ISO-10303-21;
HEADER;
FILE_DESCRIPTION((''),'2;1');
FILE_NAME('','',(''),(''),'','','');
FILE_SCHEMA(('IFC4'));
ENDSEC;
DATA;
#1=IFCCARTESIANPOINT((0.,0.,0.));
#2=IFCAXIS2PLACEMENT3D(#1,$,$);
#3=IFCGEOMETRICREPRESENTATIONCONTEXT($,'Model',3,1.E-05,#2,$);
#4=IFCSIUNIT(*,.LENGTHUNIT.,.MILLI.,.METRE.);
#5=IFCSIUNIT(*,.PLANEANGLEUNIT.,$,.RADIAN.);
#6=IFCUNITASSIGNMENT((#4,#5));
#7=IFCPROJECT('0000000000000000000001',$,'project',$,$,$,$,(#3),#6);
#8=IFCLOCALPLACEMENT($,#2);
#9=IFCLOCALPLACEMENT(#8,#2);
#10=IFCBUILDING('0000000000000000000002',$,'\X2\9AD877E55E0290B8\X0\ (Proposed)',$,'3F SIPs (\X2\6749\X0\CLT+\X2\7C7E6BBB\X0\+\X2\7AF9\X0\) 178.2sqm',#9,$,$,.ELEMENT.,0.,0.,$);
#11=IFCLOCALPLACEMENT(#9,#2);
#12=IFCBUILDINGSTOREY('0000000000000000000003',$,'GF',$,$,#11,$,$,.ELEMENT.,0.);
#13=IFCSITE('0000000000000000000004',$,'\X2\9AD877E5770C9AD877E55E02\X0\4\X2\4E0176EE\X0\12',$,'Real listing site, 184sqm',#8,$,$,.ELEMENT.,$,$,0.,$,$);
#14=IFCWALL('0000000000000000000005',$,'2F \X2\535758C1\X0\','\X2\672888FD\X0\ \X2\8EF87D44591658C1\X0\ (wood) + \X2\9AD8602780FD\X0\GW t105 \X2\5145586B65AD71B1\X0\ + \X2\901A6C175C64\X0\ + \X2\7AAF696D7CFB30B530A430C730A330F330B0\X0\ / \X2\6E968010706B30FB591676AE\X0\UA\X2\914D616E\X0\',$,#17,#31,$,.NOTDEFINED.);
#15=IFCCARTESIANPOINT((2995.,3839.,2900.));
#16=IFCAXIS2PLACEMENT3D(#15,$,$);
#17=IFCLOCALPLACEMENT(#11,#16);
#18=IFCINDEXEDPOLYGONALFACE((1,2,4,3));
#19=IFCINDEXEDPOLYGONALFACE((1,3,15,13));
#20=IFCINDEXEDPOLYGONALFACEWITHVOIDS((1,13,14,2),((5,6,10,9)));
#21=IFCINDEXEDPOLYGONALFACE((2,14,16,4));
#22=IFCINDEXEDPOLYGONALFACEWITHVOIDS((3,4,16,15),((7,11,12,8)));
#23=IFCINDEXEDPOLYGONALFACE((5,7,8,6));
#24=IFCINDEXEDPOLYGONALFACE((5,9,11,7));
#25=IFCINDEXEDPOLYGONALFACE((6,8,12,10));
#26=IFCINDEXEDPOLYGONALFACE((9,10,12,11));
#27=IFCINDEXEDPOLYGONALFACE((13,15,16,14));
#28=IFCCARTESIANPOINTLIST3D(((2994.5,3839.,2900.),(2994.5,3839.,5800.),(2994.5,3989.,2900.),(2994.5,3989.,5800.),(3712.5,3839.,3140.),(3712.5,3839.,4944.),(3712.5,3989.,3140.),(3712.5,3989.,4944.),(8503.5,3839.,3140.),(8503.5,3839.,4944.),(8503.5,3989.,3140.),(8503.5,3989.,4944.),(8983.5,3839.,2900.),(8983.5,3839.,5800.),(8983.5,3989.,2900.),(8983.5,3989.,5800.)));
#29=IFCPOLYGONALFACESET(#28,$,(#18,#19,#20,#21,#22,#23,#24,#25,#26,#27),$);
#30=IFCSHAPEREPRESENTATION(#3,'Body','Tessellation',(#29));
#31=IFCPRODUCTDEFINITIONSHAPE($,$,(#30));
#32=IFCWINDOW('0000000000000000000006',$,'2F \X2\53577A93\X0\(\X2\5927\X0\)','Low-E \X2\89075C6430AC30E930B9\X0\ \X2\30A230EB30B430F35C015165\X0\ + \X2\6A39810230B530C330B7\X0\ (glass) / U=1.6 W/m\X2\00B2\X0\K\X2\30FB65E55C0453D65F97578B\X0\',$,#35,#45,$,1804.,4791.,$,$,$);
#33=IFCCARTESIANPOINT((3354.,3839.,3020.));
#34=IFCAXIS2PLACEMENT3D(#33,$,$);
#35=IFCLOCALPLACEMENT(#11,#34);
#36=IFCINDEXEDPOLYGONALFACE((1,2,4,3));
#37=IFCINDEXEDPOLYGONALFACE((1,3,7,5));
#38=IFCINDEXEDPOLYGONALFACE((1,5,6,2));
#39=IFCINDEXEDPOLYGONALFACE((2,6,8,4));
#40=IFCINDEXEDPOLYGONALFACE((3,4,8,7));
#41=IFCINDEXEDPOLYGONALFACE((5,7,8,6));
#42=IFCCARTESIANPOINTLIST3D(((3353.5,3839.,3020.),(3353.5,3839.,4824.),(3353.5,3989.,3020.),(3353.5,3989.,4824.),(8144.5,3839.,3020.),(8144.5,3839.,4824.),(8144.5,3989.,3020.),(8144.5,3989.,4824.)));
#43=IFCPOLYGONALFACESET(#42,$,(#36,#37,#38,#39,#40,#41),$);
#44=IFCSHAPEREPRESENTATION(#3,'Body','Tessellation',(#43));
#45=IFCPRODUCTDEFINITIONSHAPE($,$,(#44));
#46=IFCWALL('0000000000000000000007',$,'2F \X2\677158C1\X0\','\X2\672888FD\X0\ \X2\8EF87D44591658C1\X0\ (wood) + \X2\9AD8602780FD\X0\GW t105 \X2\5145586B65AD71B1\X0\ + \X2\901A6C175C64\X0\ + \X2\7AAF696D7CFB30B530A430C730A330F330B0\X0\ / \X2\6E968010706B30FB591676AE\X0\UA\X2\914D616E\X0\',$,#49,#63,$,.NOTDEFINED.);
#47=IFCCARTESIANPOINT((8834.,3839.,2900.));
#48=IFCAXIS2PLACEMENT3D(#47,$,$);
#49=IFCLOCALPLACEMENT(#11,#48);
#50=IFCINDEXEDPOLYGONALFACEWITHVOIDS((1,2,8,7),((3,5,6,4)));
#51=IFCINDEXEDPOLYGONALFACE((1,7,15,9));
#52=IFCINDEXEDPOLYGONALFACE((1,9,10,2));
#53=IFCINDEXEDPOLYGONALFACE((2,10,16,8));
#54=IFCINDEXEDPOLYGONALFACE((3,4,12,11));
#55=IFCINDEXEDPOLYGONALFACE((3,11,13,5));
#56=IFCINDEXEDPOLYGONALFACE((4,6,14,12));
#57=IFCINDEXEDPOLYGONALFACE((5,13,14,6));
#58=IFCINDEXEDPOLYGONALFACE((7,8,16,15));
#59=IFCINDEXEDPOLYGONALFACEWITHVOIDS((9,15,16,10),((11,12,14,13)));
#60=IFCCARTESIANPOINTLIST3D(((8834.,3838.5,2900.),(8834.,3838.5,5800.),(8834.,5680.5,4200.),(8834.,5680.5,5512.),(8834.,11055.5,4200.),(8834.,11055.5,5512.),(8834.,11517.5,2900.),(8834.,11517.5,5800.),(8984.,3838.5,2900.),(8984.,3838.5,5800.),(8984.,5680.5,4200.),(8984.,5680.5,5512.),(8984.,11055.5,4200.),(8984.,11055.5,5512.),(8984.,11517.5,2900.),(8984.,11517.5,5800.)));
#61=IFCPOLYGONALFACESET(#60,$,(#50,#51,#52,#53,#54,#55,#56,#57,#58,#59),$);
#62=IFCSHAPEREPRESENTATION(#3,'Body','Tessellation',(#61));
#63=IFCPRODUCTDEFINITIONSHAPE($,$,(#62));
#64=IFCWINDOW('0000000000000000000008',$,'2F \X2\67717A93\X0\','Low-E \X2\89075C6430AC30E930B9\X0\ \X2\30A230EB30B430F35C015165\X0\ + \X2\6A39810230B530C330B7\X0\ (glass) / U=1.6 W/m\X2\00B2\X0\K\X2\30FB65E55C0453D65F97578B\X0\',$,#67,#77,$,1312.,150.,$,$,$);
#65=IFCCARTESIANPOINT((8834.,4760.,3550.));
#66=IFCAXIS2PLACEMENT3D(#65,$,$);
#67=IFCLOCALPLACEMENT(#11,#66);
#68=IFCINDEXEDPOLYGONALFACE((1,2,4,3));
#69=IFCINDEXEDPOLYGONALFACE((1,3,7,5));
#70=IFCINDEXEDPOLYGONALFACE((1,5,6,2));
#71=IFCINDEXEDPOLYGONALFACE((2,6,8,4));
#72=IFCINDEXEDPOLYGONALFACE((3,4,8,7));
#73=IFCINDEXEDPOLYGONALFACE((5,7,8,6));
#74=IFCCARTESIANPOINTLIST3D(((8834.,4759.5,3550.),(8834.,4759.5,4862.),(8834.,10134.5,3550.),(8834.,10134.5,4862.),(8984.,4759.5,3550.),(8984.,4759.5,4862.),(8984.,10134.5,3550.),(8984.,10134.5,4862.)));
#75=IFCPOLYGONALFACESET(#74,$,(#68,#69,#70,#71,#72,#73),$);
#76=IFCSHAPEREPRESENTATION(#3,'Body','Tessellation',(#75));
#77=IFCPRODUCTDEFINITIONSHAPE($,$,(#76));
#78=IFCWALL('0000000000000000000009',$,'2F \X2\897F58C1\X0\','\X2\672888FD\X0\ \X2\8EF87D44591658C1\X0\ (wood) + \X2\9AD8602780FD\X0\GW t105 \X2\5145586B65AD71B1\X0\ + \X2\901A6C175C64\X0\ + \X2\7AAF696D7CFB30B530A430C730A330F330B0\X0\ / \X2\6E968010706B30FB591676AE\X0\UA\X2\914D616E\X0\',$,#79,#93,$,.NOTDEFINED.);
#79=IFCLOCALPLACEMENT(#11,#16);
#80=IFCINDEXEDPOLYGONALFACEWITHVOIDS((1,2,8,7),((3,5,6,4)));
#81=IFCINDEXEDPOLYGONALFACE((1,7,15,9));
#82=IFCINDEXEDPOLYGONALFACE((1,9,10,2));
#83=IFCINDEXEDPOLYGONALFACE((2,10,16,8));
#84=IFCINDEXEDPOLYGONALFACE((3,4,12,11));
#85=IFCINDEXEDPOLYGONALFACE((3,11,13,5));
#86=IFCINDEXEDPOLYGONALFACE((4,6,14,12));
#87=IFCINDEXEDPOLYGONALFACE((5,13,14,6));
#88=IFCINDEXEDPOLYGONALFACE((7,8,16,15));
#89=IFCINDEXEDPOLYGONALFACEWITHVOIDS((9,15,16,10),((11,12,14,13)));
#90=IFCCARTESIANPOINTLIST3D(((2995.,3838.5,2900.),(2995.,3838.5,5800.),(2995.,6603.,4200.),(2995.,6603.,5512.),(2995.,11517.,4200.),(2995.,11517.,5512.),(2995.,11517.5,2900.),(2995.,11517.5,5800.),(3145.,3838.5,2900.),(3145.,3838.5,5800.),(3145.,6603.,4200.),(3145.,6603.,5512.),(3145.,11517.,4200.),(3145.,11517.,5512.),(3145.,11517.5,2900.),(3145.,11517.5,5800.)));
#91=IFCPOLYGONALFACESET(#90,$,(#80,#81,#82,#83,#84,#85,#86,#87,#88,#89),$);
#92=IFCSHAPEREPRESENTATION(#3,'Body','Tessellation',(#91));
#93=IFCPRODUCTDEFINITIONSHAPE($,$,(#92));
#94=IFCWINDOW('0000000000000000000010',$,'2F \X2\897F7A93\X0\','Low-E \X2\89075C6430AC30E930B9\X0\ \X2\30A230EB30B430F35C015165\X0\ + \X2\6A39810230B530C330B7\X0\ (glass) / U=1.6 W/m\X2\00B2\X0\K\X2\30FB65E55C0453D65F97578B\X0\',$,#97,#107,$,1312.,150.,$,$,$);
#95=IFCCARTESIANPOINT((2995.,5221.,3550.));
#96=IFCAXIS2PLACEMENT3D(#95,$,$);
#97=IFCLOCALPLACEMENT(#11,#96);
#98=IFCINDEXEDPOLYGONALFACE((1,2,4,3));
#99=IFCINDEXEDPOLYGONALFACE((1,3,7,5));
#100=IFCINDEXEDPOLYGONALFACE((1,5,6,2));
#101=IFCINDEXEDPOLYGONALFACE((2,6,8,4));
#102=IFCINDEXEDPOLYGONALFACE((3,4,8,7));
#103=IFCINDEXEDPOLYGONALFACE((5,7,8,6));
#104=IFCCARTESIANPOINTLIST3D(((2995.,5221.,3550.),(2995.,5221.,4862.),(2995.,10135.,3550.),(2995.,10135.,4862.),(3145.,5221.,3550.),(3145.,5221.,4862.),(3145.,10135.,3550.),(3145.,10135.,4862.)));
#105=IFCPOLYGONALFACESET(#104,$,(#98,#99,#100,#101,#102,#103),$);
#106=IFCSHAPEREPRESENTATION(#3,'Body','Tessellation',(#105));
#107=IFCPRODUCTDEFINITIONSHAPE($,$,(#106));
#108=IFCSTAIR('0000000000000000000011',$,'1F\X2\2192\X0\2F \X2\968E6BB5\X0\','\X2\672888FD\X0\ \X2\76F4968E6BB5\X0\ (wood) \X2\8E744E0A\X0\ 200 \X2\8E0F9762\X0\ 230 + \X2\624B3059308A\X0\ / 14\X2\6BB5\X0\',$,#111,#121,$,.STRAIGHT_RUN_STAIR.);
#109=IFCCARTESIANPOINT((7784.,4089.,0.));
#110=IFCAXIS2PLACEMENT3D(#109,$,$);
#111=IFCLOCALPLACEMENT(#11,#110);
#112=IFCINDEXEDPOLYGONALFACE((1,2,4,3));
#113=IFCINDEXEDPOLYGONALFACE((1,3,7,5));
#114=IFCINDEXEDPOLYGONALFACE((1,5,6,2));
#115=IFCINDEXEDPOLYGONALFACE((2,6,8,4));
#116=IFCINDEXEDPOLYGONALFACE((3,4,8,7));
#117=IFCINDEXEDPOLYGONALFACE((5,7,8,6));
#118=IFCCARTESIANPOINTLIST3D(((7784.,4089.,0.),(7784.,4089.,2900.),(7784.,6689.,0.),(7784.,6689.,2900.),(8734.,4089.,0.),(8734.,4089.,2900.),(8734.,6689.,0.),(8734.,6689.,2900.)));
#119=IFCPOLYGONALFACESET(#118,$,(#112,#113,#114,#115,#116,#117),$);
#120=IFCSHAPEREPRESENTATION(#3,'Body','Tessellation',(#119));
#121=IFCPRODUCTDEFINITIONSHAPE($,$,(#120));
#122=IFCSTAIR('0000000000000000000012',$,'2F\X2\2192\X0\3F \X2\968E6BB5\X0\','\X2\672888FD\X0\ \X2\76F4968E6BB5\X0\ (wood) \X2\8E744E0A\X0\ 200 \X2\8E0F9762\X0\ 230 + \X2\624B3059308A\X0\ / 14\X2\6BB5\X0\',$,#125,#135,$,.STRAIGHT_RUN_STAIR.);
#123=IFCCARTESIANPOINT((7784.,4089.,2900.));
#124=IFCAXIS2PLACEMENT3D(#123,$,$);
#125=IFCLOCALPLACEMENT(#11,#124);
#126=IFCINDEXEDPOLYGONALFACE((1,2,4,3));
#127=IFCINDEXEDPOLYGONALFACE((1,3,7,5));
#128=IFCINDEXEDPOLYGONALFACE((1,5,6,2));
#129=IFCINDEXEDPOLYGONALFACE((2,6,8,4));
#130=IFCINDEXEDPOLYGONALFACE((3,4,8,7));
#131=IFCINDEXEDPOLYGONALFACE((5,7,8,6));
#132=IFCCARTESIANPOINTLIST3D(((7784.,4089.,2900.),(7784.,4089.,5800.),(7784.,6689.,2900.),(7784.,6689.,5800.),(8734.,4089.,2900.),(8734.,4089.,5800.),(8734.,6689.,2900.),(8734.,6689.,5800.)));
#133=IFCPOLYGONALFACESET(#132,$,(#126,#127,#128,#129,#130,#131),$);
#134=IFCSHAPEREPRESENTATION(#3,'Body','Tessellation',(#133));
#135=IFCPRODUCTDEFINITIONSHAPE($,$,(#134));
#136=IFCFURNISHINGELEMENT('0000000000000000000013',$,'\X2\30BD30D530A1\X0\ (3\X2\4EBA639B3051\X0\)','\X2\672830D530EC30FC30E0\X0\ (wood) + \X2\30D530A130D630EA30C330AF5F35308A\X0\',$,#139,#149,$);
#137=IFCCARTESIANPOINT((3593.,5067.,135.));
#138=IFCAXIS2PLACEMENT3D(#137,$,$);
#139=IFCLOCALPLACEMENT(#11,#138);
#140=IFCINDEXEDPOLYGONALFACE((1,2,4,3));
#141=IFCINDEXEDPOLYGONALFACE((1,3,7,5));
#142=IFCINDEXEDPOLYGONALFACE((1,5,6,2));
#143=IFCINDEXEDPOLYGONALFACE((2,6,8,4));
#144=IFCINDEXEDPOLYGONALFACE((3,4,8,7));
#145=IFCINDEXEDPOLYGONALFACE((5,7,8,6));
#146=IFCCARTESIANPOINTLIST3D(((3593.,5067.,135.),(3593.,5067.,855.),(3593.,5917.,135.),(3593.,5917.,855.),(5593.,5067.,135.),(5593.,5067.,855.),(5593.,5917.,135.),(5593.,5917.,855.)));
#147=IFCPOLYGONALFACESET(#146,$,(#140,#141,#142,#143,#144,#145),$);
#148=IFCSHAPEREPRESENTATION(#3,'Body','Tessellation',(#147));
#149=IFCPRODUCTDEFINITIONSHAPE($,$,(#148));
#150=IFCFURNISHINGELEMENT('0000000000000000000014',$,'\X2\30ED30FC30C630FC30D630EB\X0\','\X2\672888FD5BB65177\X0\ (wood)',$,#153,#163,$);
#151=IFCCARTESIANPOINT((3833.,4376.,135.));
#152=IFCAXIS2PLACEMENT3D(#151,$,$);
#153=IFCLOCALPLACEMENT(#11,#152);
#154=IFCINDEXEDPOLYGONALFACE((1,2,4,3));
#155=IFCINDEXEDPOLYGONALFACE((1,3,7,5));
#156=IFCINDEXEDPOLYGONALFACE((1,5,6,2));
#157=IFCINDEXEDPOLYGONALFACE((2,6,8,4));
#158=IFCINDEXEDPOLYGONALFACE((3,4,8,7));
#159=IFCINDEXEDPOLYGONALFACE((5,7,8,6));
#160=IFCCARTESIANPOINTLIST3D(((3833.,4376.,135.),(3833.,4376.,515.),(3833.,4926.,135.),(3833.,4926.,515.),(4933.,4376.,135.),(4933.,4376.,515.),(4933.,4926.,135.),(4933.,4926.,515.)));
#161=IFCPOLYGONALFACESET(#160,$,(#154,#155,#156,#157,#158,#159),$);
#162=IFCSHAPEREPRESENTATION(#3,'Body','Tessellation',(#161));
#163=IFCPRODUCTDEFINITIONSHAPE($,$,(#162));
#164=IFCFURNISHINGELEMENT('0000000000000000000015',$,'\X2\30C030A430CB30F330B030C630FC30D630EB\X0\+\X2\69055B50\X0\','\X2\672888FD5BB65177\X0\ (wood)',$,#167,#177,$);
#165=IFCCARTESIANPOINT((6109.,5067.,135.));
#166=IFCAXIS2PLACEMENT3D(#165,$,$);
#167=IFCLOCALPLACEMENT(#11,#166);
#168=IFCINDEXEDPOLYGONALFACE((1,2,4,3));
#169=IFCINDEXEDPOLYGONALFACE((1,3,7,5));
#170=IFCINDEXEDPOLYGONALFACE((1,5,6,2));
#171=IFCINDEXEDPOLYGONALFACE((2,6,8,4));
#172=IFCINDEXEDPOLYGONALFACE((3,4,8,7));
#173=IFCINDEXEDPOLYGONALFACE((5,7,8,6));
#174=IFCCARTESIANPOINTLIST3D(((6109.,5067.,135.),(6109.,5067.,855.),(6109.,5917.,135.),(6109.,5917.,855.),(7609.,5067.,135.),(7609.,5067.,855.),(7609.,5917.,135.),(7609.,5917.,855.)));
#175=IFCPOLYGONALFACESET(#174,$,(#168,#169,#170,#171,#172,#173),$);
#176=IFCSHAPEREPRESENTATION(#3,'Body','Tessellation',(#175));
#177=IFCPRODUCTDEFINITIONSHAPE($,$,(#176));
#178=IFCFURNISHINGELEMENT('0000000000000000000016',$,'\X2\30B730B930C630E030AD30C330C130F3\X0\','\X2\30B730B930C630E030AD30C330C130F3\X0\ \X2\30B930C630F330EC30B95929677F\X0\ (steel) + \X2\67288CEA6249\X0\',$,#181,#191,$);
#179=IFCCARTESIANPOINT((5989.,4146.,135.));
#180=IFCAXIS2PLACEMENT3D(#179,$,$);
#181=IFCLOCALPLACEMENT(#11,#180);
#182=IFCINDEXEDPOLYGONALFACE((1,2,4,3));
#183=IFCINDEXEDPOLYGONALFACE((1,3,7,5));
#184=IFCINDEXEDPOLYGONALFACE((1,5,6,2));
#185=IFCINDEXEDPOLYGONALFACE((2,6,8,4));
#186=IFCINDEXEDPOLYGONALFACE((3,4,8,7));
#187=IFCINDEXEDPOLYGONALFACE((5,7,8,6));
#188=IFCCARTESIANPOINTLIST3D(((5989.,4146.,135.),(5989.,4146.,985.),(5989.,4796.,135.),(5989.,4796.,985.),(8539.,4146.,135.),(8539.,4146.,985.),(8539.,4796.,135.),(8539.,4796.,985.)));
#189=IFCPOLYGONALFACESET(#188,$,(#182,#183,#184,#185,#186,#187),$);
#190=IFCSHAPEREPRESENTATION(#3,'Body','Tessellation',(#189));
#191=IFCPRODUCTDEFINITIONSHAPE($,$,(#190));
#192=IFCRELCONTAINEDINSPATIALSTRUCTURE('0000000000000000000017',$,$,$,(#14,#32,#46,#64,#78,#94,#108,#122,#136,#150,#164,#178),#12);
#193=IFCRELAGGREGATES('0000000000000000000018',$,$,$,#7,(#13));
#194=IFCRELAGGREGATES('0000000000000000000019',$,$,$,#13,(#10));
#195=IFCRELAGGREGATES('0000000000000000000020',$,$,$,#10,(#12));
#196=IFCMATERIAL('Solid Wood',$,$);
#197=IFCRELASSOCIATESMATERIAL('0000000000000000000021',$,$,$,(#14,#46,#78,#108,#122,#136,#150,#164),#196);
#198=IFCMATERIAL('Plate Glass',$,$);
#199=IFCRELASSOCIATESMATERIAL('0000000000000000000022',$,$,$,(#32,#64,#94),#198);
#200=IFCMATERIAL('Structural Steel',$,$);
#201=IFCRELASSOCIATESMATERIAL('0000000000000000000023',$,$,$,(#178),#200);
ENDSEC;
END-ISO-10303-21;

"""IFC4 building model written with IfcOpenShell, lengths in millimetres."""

from ifc_helpers import new_model, si_unit, frame, frame_2d, origin, place, context, project, spatial, rectangle, extrude, material, element, fill, save


model = new_model("IFC4")

# Units and contexts
model_context = context("Model", 3, precision=1e-05, world=origin())
ifc_project = project(units=[si_unit("LENGTHUNIT", "METRE", prefix="MILLI"), si_unit("PLANEANGLEUNIT", "RADIAN")], contexts=[model_context])

# Site, building, storey
site_placement = place(None, origin())
site = spatial("IfcSite", under=ifc_project, at=site_placement, Name="高知県高知市4丁目12", ObjectType="Real listing site, 184sqm", CompositionType="ELEMENT", RefElevation=0.0)
building_placement = place(site_placement, origin())
building = spatial("IfcBuilding", under=site, at=building_placement, Name="高知市邸 (Proposed)", ObjectType="3F SIPs (杉CLT+籾殻+竹) 178.2sqm", CompositionType="ELEMENT", ElevationOfRefHeight=0.0, ElevationOfTerrain=0.0)
storey_placement = place(building_placement, origin())
storey = spatial("IfcBuildingStorey", under=building, at=storey_placement, Name="GF", CompositionType="ELEMENT", Elevation=0.0)

# Shared definitions
ifc_material_1 = material(Name="Solid Wood")

# Shared definitions
ifc_material_2 = material(Name="Plate Glass")

# Walls, openings, windows
wall_1_placement = place(storey_placement, frame((2995.0, 3839.0, 2900.0)))
wall_1 = element("IfcWall", 1, at=wall_1_placement, inside=storey, material=ifc_material_1, Name="2F 南壁", Description="木製 軸組外壁 (wood) + 高性能GW t105 充填断熱 + 通気層 + 窯業系サイディング / 準耐火・外皮UA配慮", PredefinedType="NOTDEFINED", context=model_context, shape_type="SweptSolid", body=[
    extrude(rectangle(XDim=5989.0, YDim=150.0, at=frame_2d((2994.0, 75.0))), frame((2995.0, 3839.0, 2900.0)), (0.0, 0.0, 1.0), 2900.0),
])
opening_1_placement = place(storey_placement, frame((3354.0, 3839.0, 3020.0)))
opening_1 = element("IfcOpeningElement", 2, at=opening_1_placement, cuts=wall_1, PredefinedType="NOTDEFINED", context=model_context, shape_type="SweptSolid", body=[
    extrude(rectangle(XDim=4791.0, YDim=150.0, at=frame_2d((2395.0, 75.0))), frame((3354.0, 3839.0, 3020.0)), (0.0, 0.0, 1.0), 1804.0),
])
window_1_placement = place(storey_placement, frame((3354.0, 3839.0, 3020.0)))
window_1 = element("IfcWindow", 3, at=window_1_placement, inside=storey, material=ifc_material_2, Name="2F 南窓(大)", Description="Low-E 複層ガラス アルゴン封入 + 樹脂サッシ (glass) / U=1.6 W/m²K・日射取得型", OverallHeight=1804.0, OverallWidth=4791.0, context=model_context, shape_type="SweptSolid", body=[
    extrude(rectangle(XDim=4791.0, YDim=150.0, at=frame_2d((2395.0, 75.0))), frame((3354.0, 3839.0, 3020.0)), (0.0, 0.0, 1.0), 1804.0),
])
fill(opening_1, window_1)
wall_2_placement = place(storey_placement, frame((8834.0, 3839.0, 2900.0)))
wall_2 = element("IfcWall", 4, at=wall_2_placement, inside=storey, material=ifc_material_1, Name="2F 東壁", Description="木製 軸組外壁 (wood) + 高性能GW t105 充填断熱 + 通気層 + 窯業系サイディング / 準耐火・外皮UA配慮", PredefinedType="NOTDEFINED", context=model_context, shape_type="SweptSolid", body=[
    extrude(rectangle(XDim=150.0, YDim=7679.0, at=frame_2d((75.0, 3839.0))), frame((8834.0, 3839.0, 2900.0)), (0.0, 0.0, 1.0), 2900.0),
])
opening_2_placement = place(storey_placement, frame((8834.0, 4760.0, 3550.0)))
opening_2 = element("IfcOpeningElement", 5, at=opening_2_placement, cuts=wall_2, PredefinedType="NOTDEFINED", context=model_context, shape_type="SweptSolid", body=[
    extrude(rectangle(XDim=150.0, YDim=5375.0, at=frame_2d((75.0, 2687.0))), frame((8834.0, 4760.0, 3550.0)), (0.0, 0.0, 1.0), 1312.0),
])
window_2_placement = place(storey_placement, frame((8834.0, 4760.0, 3550.0)))
window_2 = element("IfcWindow", 6, at=window_2_placement, inside=storey, material=ifc_material_2, Name="2F 東窓", Description="Low-E 複層ガラス アルゴン封入 + 樹脂サッシ (glass) / U=1.6 W/m²K・日射取得型", OverallHeight=1312.0, OverallWidth=150.0, context=model_context, shape_type="SweptSolid", body=[
    extrude(rectangle(XDim=150.0, YDim=5375.0, at=frame_2d((75.0, 2687.0))), frame((8834.0, 4760.0, 3550.0)), (0.0, 0.0, 1.0), 1312.0),
])
fill(opening_2, window_2)
wall_3_placement = place(storey_placement, frame((2995.0, 3839.0, 2900.0)))
wall_3 = element("IfcWall", 7, at=wall_3_placement, inside=storey, material=ifc_material_1, Name="2F 西壁", Description="木製 軸組外壁 (wood) + 高性能GW t105 充填断熱 + 通気層 + 窯業系サイディング / 準耐火・外皮UA配慮", PredefinedType="NOTDEFINED", context=model_context, shape_type="SweptSolid", body=[
    extrude(rectangle(XDim=150.0, YDim=7679.0, at=frame_2d((75.0, 3839.0))), frame((2995.0, 3839.0, 2900.0)), (0.0, 0.0, 1.0), 2900.0),
])
opening_3_placement = place(storey_placement, frame((2995.0, 5221.0, 3550.0)))
opening_3 = element("IfcOpeningElement", 8, at=opening_3_placement, cuts=wall_3, PredefinedType="NOTDEFINED", context=model_context, shape_type="SweptSolid", body=[
    extrude(rectangle(XDim=150.0, YDim=4914.0, at=frame_2d((75.0, 2457.0))), frame((2995.0, 5221.0, 3550.0)), (0.0, 0.0, 1.0), 1312.0),
])
window_3_placement = place(storey_placement, frame((2995.0, 5221.0, 3550.0)))
window_3 = element("IfcWindow", 9, at=window_3_placement, inside=storey, material=ifc_material_2, Name="2F 西窓", Description="Low-E 複層ガラス アルゴン封入 + 樹脂サッシ (glass) / U=1.6 W/m²K・日射取得型", OverallHeight=1312.0, OverallWidth=150.0, context=model_context, shape_type="SweptSolid", body=[
    extrude(rectangle(XDim=150.0, YDim=4914.0, at=frame_2d((75.0, 2457.0))), frame((2995.0, 5221.0, 3550.0)), (0.0, 0.0, 1.0), 1312.0),
])
fill(opening_3, window_3)

# Stairs
stair_1_placement = place(storey_placement, frame((7784.0, 4089.0, 0.0)))
element("IfcStair", 10, at=stair_1_placement, inside=storey, material=ifc_material_1, Name="1F→2F 階段", Description="木製 直階段 (wood) 蹴上 200 踏面 230 + 手すり / 14段", PredefinedType="STRAIGHT_RUN_STAIR", context=model_context, shape_type="SweptSolid", body=[
    extrude(rectangle(XDim=950.0, YDim=2600.0, at=frame_2d((475.0, 1300.0))), frame((7784.0, 4089.0, 0.0)), (0.0, 0.0, 1.0), 2900.0),
])
stair_2_placement = place(storey_placement, frame((7784.0, 4089.0, 2900.0)))
element("IfcStair", 11, at=stair_2_placement, inside=storey, material=ifc_material_1, Name="2F→3F 階段", Description="木製 直階段 (wood) 蹴上 200 踏面 230 + 手すり / 14段", PredefinedType="STRAIGHT_RUN_STAIR", context=model_context, shape_type="SweptSolid", body=[
    extrude(rectangle(XDim=950.0, YDim=2600.0, at=frame_2d((475.0, 1300.0))), frame((7784.0, 4089.0, 2900.0)), (0.0, 0.0, 1.0), 2900.0),
])

# Furnishing elements
furnishing_1_placement = place(storey_placement, frame((3593.0, 5067.0, 135.0)))
element("IfcFurnishingElement", 12, at=furnishing_1_placement, inside=storey, material=ifc_material_1, Name="ソファ (3人掛け)", Description="木フレーム (wood) + ファブリック張り", context=model_context, shape_type="SweptSolid", body=[
    extrude(rectangle(XDim=2000.0, YDim=850.0, at=frame_2d((1000.0, 425.0))), frame((3593.0, 5067.0, 135.0)), (0.0, 0.0, 1.0), 720.0),
])
furnishing_2_placement = place(storey_placement, frame((3833.0, 4376.0, 135.0)))
element("IfcFurnishingElement", 13, at=furnishing_2_placement, inside=storey, material=ifc_material_1, Name="ローテーブル", Description="木製家具 (wood)", context=model_context, shape_type="SweptSolid", body=[
    extrude(rectangle(XDim=1100.0, YDim=550.0, at=frame_2d((550.0, 275.0))), frame((3833.0, 4376.0, 135.0)), (0.0, 0.0, 1.0), 380.0),
])
furnishing_3_placement = place(storey_placement, frame((6109.0, 5067.0, 135.0)))
element("IfcFurnishingElement", 14, at=furnishing_3_placement, inside=storey, material=ifc_material_1, Name="ダイニングテーブル+椅子", Description="木製家具 (wood)", context=model_context, shape_type="SweptSolid", body=[
    extrude(rectangle(XDim=1500.0, YDim=850.0, at=frame_2d((750.0, 425.0))), frame((6109.0, 5067.0, 135.0)), (0.0, 0.0, 1.0), 720.0),
])
ifc_material_3 = material(Name="Structural Steel")
furnishing_4_placement = place(storey_placement, frame((5989.0, 4146.0, 135.0)))
element("IfcFurnishingElement", 15, at=furnishing_4_placement, inside=storey, material=ifc_material_3, Name="システムキッチン", Description="システムキッチン ステンレス天板 (steel) + 木質扉", context=model_context, shape_type="SweptSolid", body=[
    extrude(rectangle(XDim=2550.0, YDim=650.0, at=frame_2d((1275.0, 325.0))), frame((5989.0, 4146.0, 135.0)), (0.0, 0.0, 1.0), 850.0),
])

save(model, "model.ifc")
